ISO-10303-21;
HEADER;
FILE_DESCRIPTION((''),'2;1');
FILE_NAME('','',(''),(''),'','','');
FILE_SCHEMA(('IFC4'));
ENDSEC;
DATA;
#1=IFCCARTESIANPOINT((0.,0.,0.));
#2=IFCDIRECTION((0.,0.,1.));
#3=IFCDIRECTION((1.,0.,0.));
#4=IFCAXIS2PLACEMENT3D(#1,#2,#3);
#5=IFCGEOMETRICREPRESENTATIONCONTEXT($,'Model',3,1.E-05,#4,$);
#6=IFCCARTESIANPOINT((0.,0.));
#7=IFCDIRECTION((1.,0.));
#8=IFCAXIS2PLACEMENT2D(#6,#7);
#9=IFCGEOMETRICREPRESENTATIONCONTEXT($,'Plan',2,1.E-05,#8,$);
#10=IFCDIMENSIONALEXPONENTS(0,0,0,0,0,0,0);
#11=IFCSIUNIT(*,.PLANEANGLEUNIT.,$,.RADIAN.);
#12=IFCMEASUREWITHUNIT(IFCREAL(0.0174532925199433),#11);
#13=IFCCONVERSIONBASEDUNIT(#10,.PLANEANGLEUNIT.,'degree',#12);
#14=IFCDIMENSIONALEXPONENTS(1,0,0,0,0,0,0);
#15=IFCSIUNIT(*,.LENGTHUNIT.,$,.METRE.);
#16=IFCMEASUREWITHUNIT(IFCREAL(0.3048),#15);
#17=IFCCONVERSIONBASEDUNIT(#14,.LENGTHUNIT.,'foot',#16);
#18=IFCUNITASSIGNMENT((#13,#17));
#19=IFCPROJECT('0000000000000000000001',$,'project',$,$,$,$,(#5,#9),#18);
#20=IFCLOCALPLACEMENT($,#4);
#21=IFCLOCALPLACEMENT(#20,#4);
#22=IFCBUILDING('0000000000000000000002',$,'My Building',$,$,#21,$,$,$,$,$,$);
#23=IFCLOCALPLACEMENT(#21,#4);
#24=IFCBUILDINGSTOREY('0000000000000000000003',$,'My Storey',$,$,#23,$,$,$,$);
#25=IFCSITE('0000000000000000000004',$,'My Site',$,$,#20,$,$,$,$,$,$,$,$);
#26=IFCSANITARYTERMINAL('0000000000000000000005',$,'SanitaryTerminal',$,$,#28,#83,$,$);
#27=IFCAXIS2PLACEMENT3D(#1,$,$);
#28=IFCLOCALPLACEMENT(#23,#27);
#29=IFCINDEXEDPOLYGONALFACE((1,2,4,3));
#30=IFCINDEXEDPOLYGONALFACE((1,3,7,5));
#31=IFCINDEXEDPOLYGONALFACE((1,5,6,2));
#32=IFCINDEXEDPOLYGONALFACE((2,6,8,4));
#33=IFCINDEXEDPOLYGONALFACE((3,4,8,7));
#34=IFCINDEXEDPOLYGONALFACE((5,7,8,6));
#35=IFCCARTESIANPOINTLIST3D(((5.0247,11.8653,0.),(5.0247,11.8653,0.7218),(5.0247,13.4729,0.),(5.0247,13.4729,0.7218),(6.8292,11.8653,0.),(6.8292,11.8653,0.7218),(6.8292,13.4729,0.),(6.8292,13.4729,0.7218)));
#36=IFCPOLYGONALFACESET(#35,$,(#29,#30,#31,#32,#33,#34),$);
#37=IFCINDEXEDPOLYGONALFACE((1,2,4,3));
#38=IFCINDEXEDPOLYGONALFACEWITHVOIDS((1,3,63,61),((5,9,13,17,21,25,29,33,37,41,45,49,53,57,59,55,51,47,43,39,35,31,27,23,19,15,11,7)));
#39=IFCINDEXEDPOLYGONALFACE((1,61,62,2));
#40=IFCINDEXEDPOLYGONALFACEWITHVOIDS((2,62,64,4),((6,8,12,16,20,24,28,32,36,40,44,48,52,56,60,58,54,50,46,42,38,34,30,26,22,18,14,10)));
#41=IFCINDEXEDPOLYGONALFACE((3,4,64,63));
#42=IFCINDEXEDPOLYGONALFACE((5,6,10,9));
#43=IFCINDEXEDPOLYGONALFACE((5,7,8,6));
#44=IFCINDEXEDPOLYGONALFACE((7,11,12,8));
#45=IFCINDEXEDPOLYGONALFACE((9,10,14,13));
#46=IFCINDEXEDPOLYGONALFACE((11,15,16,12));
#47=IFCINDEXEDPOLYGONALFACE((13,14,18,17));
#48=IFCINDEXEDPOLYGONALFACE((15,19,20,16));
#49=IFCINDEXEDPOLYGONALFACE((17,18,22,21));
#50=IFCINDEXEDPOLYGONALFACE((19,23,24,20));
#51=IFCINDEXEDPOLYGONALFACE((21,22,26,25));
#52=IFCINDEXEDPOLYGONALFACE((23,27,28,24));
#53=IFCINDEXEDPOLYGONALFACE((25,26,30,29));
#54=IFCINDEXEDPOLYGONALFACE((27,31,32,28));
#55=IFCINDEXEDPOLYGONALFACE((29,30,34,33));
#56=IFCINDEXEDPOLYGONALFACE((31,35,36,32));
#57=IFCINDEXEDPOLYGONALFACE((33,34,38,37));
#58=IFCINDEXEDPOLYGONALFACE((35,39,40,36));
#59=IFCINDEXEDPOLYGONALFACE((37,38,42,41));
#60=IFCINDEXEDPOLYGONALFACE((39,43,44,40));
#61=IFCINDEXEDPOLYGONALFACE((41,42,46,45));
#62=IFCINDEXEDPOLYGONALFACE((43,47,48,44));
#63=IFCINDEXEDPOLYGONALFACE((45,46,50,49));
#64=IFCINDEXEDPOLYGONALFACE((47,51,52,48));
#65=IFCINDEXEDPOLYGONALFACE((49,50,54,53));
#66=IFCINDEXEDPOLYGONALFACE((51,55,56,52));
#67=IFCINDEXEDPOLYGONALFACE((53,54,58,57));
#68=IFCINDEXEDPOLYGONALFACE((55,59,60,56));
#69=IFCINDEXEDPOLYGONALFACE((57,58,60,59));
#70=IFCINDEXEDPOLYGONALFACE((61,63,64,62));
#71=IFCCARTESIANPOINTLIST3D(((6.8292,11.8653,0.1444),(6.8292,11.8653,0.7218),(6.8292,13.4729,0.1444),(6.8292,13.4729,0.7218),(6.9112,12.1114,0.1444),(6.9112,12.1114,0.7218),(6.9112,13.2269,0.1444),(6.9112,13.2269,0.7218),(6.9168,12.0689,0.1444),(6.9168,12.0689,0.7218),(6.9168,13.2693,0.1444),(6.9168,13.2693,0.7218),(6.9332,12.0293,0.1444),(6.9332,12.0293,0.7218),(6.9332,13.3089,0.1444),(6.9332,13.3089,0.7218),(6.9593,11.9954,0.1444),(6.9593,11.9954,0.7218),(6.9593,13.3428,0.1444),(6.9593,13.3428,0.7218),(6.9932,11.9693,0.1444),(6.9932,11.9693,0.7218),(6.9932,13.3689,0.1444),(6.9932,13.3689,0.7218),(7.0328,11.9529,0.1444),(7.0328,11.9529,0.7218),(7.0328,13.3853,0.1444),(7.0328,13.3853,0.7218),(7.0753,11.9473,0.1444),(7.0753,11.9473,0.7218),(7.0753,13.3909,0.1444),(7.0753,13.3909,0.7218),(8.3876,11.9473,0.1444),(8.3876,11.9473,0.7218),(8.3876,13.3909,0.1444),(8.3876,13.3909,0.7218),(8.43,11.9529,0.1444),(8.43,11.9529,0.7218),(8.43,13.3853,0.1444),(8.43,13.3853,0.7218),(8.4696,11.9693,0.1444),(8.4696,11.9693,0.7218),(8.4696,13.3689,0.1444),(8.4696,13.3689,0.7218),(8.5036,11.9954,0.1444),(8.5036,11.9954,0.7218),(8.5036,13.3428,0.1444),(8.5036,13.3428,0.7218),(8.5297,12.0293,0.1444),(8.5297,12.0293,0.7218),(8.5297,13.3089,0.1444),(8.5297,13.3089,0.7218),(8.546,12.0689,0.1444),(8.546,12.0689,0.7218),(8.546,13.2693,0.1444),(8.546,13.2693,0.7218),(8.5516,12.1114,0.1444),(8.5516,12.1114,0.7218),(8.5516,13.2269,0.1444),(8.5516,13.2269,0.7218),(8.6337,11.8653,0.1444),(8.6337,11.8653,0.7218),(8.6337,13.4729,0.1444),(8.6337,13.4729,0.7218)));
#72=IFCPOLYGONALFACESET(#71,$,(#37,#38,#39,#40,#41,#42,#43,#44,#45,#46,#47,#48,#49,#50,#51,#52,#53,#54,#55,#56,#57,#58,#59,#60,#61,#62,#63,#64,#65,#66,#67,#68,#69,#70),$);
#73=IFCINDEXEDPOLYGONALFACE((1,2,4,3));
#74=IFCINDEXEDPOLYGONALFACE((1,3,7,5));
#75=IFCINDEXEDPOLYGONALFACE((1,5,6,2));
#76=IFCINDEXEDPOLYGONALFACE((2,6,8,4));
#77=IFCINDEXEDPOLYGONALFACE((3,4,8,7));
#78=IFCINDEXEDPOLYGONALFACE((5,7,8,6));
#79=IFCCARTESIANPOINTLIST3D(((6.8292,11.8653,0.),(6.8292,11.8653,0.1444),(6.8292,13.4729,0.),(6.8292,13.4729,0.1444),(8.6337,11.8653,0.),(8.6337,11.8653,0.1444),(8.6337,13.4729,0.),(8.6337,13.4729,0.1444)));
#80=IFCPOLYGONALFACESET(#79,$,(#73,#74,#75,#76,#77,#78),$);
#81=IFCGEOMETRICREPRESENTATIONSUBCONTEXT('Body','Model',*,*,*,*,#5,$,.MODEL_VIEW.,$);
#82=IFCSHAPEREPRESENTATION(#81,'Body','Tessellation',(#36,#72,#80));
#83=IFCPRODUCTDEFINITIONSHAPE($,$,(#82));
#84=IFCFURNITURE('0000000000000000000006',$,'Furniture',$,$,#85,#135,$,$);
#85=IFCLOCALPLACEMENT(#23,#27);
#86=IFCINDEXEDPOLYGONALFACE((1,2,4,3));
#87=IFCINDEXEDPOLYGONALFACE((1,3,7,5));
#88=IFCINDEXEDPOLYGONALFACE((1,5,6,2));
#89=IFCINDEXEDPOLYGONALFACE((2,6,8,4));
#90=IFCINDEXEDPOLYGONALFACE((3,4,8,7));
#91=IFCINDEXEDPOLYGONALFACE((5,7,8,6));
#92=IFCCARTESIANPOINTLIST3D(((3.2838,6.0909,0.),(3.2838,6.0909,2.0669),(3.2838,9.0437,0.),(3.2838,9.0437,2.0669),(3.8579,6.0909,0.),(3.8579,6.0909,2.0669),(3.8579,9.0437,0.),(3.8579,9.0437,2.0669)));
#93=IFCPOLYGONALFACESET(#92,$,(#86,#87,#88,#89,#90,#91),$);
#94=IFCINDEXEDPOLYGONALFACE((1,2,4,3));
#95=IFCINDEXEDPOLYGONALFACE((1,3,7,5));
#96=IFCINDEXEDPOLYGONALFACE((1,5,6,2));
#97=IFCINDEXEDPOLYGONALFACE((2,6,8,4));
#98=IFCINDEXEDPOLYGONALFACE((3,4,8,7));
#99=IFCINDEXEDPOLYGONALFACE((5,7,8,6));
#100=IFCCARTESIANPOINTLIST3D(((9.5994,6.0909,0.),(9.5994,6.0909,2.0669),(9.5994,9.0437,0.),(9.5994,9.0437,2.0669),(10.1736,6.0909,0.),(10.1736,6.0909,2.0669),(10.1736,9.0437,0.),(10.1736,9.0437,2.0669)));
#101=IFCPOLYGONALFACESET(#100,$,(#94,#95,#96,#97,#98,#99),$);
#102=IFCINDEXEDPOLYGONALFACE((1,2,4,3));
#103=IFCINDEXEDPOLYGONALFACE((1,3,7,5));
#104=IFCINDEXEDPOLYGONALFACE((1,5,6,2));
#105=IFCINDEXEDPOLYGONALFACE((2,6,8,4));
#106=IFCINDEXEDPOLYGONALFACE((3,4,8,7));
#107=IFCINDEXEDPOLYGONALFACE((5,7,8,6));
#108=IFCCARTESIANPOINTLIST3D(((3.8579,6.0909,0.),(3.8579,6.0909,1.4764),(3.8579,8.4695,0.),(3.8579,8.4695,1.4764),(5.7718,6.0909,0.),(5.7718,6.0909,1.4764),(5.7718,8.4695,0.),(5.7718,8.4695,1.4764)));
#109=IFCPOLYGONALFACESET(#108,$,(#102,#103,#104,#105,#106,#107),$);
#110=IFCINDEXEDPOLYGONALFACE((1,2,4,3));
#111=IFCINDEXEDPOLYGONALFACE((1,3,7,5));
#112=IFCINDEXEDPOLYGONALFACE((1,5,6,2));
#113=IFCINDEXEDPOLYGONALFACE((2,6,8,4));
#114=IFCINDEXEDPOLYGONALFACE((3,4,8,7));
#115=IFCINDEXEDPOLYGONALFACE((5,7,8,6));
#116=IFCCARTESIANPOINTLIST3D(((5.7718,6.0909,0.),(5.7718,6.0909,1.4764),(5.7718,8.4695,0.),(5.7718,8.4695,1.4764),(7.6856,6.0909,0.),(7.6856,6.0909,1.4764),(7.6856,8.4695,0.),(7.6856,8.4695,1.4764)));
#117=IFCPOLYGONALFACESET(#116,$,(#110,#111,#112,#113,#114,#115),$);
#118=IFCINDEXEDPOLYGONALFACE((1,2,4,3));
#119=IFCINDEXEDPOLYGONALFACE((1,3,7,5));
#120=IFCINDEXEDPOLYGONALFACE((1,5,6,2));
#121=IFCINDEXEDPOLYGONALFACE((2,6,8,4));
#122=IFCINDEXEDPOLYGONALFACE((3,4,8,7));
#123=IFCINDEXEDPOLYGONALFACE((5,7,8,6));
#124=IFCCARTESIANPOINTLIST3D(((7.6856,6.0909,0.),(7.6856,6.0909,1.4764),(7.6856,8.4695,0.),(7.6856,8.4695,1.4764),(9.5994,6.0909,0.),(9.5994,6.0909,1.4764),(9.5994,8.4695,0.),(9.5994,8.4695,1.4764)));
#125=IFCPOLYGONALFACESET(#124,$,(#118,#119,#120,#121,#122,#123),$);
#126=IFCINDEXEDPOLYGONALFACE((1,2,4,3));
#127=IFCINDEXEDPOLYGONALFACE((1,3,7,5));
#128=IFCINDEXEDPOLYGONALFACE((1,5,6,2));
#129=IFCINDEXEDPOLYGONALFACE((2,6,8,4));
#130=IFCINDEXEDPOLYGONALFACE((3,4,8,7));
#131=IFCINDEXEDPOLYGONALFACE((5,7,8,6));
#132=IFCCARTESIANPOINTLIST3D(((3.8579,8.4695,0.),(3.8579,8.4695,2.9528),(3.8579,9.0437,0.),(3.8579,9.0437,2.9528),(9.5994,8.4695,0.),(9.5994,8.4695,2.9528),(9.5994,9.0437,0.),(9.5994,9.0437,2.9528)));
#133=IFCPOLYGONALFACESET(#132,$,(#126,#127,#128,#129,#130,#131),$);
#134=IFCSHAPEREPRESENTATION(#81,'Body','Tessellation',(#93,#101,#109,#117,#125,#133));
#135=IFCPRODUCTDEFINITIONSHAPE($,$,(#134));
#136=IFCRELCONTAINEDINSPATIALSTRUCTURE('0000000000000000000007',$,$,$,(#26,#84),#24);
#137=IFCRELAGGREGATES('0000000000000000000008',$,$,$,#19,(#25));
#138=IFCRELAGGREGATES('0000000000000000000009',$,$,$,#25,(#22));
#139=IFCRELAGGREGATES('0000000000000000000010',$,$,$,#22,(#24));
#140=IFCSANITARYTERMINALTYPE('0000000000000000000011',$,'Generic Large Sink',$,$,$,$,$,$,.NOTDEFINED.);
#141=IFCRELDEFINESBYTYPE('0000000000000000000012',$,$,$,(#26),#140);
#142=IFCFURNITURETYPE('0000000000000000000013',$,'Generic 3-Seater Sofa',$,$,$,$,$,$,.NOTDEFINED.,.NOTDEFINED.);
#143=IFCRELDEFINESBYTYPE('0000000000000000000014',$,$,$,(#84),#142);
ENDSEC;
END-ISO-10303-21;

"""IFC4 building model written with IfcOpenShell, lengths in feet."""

from ifc_helpers import new_model, entity, si_unit, converted_unit, frame, origin_with_axes, origin_2d_with_axis, place, context, subcontext, project, spatial, line, indexed_curve, outline, extrude, shape, source, transform, mapped, type_object, type_shapes, element, save


model = new_model("IFC4")

# Units and contexts
model_context = context("Model", 3, precision=1e-05, world=origin_with_axes())
plan_context = context("Plan", 2, precision=1e-05, world=origin_2d_with_axis())
body_context_1 = subcontext(model_context, "Body", "Model", "MODEL_VIEW")
body_context_2 = subcontext(plan_context, "Body", "Plan", "PLAN_VIEW")
ifc_project = project(units=[converted_unit("PLANEANGLEUNIT", "degree", entity("IfcReal", 0.0174532925199433), si_unit("PLANEANGLEUNIT", "RADIAN"), dimensions=[0, 0, 0, 0, 0, 0, 0]), converted_unit("LENGTHUNIT", "foot", entity("IfcReal", 0.3048), si_unit("LENGTHUNIT", "METRE"), dimensions=[1, 0, 0, 0, 0, 0, 0])], contexts=[model_context, plan_context])

# Site, building, storey
site_placement = place(None, origin_with_axes())
site = spatial("IfcSite", under=ifc_project, at=site_placement, Name="My Site")
building_placement = place(site_placement, origin_with_axes())
building = spatial("IfcBuilding", under=site, at=building_placement, Name="My Building")
storey_placement = place(building_placement, origin_with_axes())
storey = spatial("IfcBuildingStorey", under=building, at=storey_placement, Name="My Storey")

# Sanitary terminal
sanitary_terminal_type = type_object("IfcSanitaryTerminalType", Name="Generic Large Sink", PredefinedType="NOTDEFINED")
shared_indexed_poly_curve = entity("IfcIndexedPolyCurve", entity("IfcCartesianPointList2D", [[1.8045, 0.0], [3.6089, 0.0], [3.6089, 1.6076], [1.8045, 1.6076]]), [entity("IfcLineIndex", [1, 2, 3, 4, 1])])
shared_shape_1 = source(origin_with_axes(), body_context_1, "Body", "SweptSolid", [
    extrude(outline(indexed_curve([(0.0, 0.0), (1.8045, 0.0), (1.8045, 1.6076), (0.0, 1.6076)], segments=[line(1, 2, 3, 4, 1)])), frame((-1.8045, -1.6076, 0.0), z_axis=(0.0, 0.0, 1.0), x_axis=(1.0, 0.0, 0.0)), (0.0, 0.0, 1.0), 0.7218),
    entity("IfcExtrudedAreaSolid", entity("IfcArbitraryProfileDefWithVoids", "AREA", None, shared_indexed_poly_curve, [entity("IfcIndexedPolyCurve", entity("IfcCartesianPointList2D", [[1.8865, 0.2461], [1.9345, 0.1301], [2.0505, 0.082], [3.3629, 0.082], [3.4789, 0.1301], [3.5269, 0.2461], [3.5269, 1.3615], [3.4789, 1.4775], [3.3629, 1.5256], [2.0505, 1.5256], [1.9345, 1.4775], [1.8865, 1.3615]]), [entity("IfcLineIndex", [12, 1]), entity("IfcArcIndex", [1, 2, 3]), entity("IfcLineIndex", [3, 4]), entity("IfcArcIndex", [4, 5, 6]), entity("IfcLineIndex", [6, 7]), entity("IfcArcIndex", [7, 8, 9]), entity("IfcLineIndex", [9, 10]), entity("IfcArcIndex", [10, 11, 12]), entity("IfcLineIndex", [12, 1])])]), entity("IfcAxis2Placement3D", entity("IfcCartesianPoint", [-1.8045, -1.6076, 0.1444]), entity("IfcDirection", [0.0, 0.0, 1.0]), entity("IfcDirection", [1.0, 0.0, 0.0])), entity("IfcDirection", [0.0, 0.0, 1.0]), 0.5774),
    entity("IfcExtrudedAreaSolid", entity("IfcArbitraryClosedProfileDef", "AREA", None, shared_indexed_poly_curve), entity("IfcAxis2Placement3D", entity("IfcCartesianPoint", [-1.8045, -1.6076, 0.0]), entity("IfcDirection", [0.0, 0.0, 1.0]), entity("IfcDirection", [1.0, 0.0, 0.0])), entity("IfcDirection", [0.0, 0.0, 1.0]), 0.1444),
])
shared_shape_2 = source(origin_with_axes(), body_context_2, "Body", "Curve2D", [
    entity("IfcIndexedPolyCurve", entity("IfcCartesianPointList2D", [[-1.8045, -1.6076], [1.8045, -1.6076], [1.8045, 0.0], [-1.8045, 0.0]]), [entity("IfcLineIndex", [1, 2, 3, 4, 1])]),
    entity("IfcIndexedPolyCurve", entity("IfcCartesianPointList2D", [[0.082, -1.3615], [0.1301, -1.4775], [0.2461, -1.5256], [1.5584, -1.5256], [1.6744, -1.4775], [1.7224, -1.3615], [1.7224, -0.2461], [1.6744, -0.1301], [1.5584, -0.082], [0.2461, -0.082], [0.1301, -0.1301], [0.082, -0.2461]]), [entity("IfcLineIndex", [12, 1]), entity("IfcArcIndex", [1, 2, 3]), entity("IfcLineIndex", [3, 4]), entity("IfcArcIndex", [4, 5, 6]), entity("IfcLineIndex", [6, 7]), entity("IfcArcIndex", [7, 8, 9]), entity("IfcLineIndex", [9, 10]), entity("IfcArcIndex", [10, 11, 12]), entity("IfcLineIndex", [12, 1])]),
    entity("IfcCircle", entity("IfcAxis2Placement2D", entity("IfcCartesianPoint", [0.9022, -0.4101])), 0.082),
    entity("IfcIndexedPolyCurve", entity("IfcCartesianPointList2D", [[0.9022, -0.041], [0.9022, -0.4347]])),
])
type_shapes(sanitary_terminal_type, [shared_shape_1, shared_shape_2])
sanitary_terminal_placement = place(storey_placement, frame((6.8292, 13.4729, 0.0), z_axis=(0.0, 0.0, 1.0), x_axis=(1.0, 0.0, 0.0)))
element("IfcSanitaryTerminal", 1, at=sanitary_terminal_placement, inside=storey, type_object=sanitary_terminal_type, Name="SanitaryTerminal", shapes=[
    shape(body_context_1, "Body", "MappedRepresentation", [mapped(shared_shape_1, transform((0.0, 0.0, 0.0), x_axis=(1.0, 0.0, 0.0), y_axis=(0.0, 1.0, 0.0), z_axis=(0.0, 0.0, 1.0), scale=1.0))]),
    shape(body_context_2, "Body", "MappedRepresentation", [mapped(shared_shape_2, transform((0.0, 0.0, 0.0), x_axis=(1.0, 0.0, 0.0), y_axis=(0.0, 1.0, 0.0), z_axis=(0.0, 0.0, 1.0), scale=1.0))]),
])

# Furniture
furniture_type = type_object("IfcFurnitureType", Name="Generic 3-Seater Sofa", AssemblyPlace="NOTDEFINED", PredefinedType="NOTDEFINED")
shared_shape_3 = source(origin_with_axes(), body_context_1, "Body", "SweptSolid", [
    extrude(outline(indexed_curve([(0.0, 0.0), (0.5741, 0.0), (0.5741, 2.9528), (0.0, 2.9528)], segments=[line(1, 2, 3, 4, 1)])), frame((-3.4449, -2.9528, 0.0), z_axis=(0.0, 0.0, 1.0), x_axis=(1.0, 0.0, 0.0)), (0.0, 0.0, 1.0), 2.0669),
    extrude(outline(indexed_curve([(0.0, 0.0), (0.5741, 0.0), (0.5741, 2.9528), (0.0, 2.9528)], segments=[line(1, 2, 3, 4, 1)])), frame((2.8707, -2.9528, 0.0), z_axis=(0.0, 0.0, 1.0), x_axis=(1.0, 0.0, 0.0)), (0.0, 0.0, 1.0), 2.0669),
    extrude(outline(indexed_curve([(0.5741, 0.0), (2.488, 0.0), (2.488, 2.3786), (0.5741, 2.3786)], segments=[line(1, 2, 3, 4, 1)])), frame((-3.4449, -2.9528, 0.0), z_axis=(0.0, 0.0, 1.0), x_axis=(1.0, 0.0, 0.0)), (0.0, 0.0, 1.0), 1.4764),
    extrude(outline(indexed_curve([(2.488, 0.0), (4.4018, 0.0), (4.4018, 2.3786), (2.488, 2.3786)], segments=[line(1, 2, 3, 4, 1)])), frame((-3.4449, -2.9528, 0.0), z_axis=(0.0, 0.0, 1.0), x_axis=(1.0, 0.0, 0.0)), (0.0, 0.0, 1.0), 1.4764),
    extrude(outline(indexed_curve([(4.4018, 0.0), (6.3156, 0.0), (6.3156, 2.3786), (4.4018, 2.3786)], segments=[line(1, 2, 3, 4, 1)])), frame((-3.4449, -2.9528, 0.0), z_axis=(0.0, 0.0, 1.0), x_axis=(1.0, 0.0, 0.0)), (0.0, 0.0, 1.0), 1.4764),
    extrude(outline(indexed_curve([(0.5741, 2.3786), (6.3156, 2.3786), (6.3156, 2.9528), (0.5741, 2.9528)], segments=[line(1, 2, 3, 4, 1)])), frame((-3.4449, -2.9528, 0.0), z_axis=(0.0, 0.0, 1.0), x_axis=(1.0, 0.0, 0.0)), (0.0, 0.0, 1.0), 2.9528),
])
shared_shape_4 = source(origin_with_axes(), body_context_2, "Body", "Curve2D", [
    entity("IfcIndexedPolyCurve", entity("IfcCartesianPointList2D", [[-3.4449, -2.9528], [-2.8707, -2.9528], [-2.8707, 0.0], [-3.4449, 0.0]]), [entity("IfcLineIndex", [1, 2, 3, 4, 1])]),
    entity("IfcIndexedPolyCurve", entity("IfcCartesianPointList2D", [[2.8707, -2.9528], [3.4449, -2.9528], [3.4449, 0.0], [2.8707, 0.0]]), [entity("IfcLineIndex", [1, 2, 3, 4, 1])]),
    entity("IfcIndexedPolyCurve", entity("IfcCartesianPointList2D", [[-2.8707, -2.9528], [-0.9569, -2.9528], [-0.9569, -0.5741], [-2.8707, -0.5741]]), [entity("IfcLineIndex", [1, 2, 3, 4, 1])]),
    entity("IfcIndexedPolyCurve", entity("IfcCartesianPointList2D", [[-0.9569, -2.9528], [0.9569, -2.9528], [0.9569, -0.5741], [-0.9569, -0.5741]]), [entity("IfcLineIndex", [1, 2, 3, 4, 1])]),
    entity("IfcIndexedPolyCurve", entity("IfcCartesianPointList2D", [[0.9569, -2.9528], [2.8707, -2.9528], [2.8707, -0.5741], [0.9569, -0.5741]]), [entity("IfcLineIndex", [1, 2, 3, 4, 1])]),
    entity("IfcIndexedPolyCurve", entity("IfcCartesianPointList2D", [[-2.8707, -0.5741], [2.8707, -0.5741], [2.8707, 0.0], [-2.8707, 0.0]]), [entity("IfcLineIndex", [1, 2, 3, 4, 1])]),
])
type_shapes(furniture_type, [shared_shape_3, shared_shape_4])
furniture_placement = place(storey_placement, frame((6.7287, 9.0437, 0.0), z_axis=(0.0, 0.0, 1.0), x_axis=(1.0, 0.0, 0.0)))
element("IfcFurniture", 2, at=furniture_placement, inside=storey, type_object=furniture_type, Name="Furniture", shapes=[
    shape(body_context_1, "Body", "MappedRepresentation", [mapped(shared_shape_3, transform((0.0, 0.0, 0.0), x_axis=(1.0, 0.0, 0.0), y_axis=(0.0, 1.0, 0.0), z_axis=(0.0, 0.0, 1.0), scale=1.0))]),
    shape(body_context_2, "Body", "MappedRepresentation", [mapped(shared_shape_4, transform((0.0, 0.0, 0.0), x_axis=(1.0, 0.0, 0.0), y_axis=(0.0, 1.0, 0.0), z_axis=(0.0, 0.0, 1.0), scale=1.0))]),
])

save(model, "model.ifc")
